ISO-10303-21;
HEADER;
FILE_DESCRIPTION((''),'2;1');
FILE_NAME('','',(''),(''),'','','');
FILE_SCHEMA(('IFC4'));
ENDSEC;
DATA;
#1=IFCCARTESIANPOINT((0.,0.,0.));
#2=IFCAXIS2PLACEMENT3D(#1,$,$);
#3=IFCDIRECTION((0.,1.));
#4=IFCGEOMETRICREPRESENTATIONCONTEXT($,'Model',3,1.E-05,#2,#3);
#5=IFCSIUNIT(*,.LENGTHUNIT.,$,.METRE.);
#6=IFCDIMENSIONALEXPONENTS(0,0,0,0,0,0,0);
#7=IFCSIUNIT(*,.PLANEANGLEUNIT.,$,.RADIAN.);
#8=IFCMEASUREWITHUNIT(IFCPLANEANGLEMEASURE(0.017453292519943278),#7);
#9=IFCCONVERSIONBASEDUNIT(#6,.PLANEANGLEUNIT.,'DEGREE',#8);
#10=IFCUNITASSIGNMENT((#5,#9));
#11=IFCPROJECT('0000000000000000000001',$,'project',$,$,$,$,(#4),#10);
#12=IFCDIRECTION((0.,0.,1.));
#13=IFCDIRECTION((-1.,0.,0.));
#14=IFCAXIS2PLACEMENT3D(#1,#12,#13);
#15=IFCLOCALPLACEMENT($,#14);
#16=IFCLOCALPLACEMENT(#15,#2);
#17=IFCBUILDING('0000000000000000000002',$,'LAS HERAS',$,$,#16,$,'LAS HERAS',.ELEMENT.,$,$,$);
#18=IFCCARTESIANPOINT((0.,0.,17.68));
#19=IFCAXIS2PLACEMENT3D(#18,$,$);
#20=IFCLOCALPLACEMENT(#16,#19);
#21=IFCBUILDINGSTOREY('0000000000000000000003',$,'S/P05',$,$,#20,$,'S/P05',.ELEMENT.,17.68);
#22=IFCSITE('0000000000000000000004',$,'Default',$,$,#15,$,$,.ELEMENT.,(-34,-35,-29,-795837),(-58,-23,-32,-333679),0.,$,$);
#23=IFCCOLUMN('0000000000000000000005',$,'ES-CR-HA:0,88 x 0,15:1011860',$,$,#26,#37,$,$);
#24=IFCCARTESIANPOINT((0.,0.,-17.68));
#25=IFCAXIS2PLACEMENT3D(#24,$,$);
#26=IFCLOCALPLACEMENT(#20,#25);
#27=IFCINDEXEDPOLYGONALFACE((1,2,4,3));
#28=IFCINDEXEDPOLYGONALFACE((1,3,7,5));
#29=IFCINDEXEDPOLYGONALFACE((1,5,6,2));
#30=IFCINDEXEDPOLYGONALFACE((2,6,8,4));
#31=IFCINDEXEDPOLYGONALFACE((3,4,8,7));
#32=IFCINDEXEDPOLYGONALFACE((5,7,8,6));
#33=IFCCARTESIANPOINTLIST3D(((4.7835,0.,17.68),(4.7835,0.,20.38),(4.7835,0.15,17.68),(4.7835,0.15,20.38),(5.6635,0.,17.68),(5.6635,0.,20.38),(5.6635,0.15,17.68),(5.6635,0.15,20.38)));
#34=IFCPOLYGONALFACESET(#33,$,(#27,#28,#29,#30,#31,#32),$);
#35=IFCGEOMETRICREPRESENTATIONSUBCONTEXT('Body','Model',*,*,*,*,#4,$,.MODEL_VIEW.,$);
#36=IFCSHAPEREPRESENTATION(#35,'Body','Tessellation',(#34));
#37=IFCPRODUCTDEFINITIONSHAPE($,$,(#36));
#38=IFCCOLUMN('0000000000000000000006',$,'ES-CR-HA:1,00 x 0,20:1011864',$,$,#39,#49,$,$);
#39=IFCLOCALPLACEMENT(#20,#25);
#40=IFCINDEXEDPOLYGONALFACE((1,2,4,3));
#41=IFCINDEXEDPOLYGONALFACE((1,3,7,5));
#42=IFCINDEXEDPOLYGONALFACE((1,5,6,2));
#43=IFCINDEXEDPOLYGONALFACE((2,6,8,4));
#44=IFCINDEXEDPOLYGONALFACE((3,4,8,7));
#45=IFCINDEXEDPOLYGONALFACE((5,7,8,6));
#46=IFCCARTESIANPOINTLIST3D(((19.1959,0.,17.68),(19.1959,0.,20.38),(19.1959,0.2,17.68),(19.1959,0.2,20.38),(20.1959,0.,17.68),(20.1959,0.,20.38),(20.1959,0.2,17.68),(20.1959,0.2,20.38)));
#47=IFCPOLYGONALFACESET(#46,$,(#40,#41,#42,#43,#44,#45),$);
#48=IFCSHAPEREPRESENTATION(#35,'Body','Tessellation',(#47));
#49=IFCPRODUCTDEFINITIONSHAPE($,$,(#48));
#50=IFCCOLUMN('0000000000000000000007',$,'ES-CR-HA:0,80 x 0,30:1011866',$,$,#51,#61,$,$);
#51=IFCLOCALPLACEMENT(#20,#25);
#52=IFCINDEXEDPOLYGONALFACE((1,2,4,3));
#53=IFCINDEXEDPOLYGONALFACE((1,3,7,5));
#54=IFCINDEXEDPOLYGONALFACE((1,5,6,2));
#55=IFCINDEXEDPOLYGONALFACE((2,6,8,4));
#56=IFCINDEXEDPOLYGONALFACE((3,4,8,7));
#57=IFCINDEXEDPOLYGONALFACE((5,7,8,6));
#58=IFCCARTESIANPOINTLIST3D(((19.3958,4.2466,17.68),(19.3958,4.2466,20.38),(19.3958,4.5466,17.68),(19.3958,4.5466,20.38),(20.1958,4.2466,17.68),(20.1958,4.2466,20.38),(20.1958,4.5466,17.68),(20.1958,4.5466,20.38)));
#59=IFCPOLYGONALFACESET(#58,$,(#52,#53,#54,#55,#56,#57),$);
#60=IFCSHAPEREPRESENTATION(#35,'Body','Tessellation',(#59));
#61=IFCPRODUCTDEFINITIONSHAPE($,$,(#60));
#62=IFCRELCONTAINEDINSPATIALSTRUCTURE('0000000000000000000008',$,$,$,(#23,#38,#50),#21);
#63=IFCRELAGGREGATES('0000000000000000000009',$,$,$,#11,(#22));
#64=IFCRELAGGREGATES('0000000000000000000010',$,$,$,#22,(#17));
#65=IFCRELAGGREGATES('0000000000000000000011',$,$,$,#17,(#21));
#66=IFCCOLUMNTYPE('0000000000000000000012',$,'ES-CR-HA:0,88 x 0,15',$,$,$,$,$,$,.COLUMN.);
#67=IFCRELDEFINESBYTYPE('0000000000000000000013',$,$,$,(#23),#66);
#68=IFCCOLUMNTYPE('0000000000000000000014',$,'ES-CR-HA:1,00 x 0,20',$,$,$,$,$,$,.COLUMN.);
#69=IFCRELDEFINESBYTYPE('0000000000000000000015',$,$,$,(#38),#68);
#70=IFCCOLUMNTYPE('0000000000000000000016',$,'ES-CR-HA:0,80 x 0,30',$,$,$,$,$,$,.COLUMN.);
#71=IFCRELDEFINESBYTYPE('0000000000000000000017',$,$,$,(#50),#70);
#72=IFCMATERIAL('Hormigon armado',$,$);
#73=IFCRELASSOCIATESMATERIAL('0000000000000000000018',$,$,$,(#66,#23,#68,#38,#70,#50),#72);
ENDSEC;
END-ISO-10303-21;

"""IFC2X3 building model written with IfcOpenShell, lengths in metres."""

from ifc_helpers import new_model, entity, si_unit, converted_unit, direction, frame, frame_2d, origin, origin_2d_with_axis, place, context, subcontext, project, spatial, rectangle, extrude, source, transform, mapped, material, type_object, type_shapes, element, save


model = new_model("IFC2X3")

# Units and contexts
model_context = context("Model", 3, precision=1e-05, world=origin(), true_north=direction((0.0, 1.0)))
body_context = subcontext(model_context, "Body", "Model", "MODEL_VIEW")
ifc_project = project(units=[si_unit("LENGTHUNIT", "METRE"), converted_unit("PLANEANGLEUNIT", "DEGREE", entity("IfcPlaneAngleMeasure", 0.017453292519943278), si_unit("PLANEANGLEUNIT", "RADIAN"), dimensions=[0, 0, 0, 0, 0, 0, 0])], contexts=[model_context])

# Site, building, storey
site_placement = place(None, frame((0.0, 0.0, 0.0), z_axis=(0.0, 0.0, 1.0), x_axis=(-1.0, 0.0, 0.0)))
site = spatial("IfcSite", under=ifc_project, at=site_placement, Name="Default", CompositionType="ELEMENT", RefLatitude=(-34, -35, -29, -795837), RefLongitude=(-58, -23, -32, -333679), RefElevation=0.0)
building_placement = place(site_placement, origin())
building = spatial("IfcBuilding", under=site, at=building_placement, Name="LAS HERAS", LongName="LAS HERAS", CompositionType="ELEMENT")
storey_placement = place(building_placement, frame((0.0, 0.0, 17.68)))
storey = spatial("IfcBuildingStorey", under=building, at=storey_placement, Name="S/P05", LongName="S/P05", CompositionType="ELEMENT", Elevation=17.68)

# Columns
ifc_material = material(Name="Hormigon armado")
column_type_1 = type_object("IfcColumnType", Name="ES-CR-HA:0,88 x 0,15", PredefinedType="COLUMN", material=ifc_material)
shared_shape_1 = source(origin(), body_context, "Body", "SweptSolid", [
    extrude(rectangle(XDim=2.7, YDim=0.15, at=frame_2d((0.0, 0.0), x_axis=(1.0, 0.0))), frame((4.7835, 0.075, 19.03), z_axis=(1.0, 0.0, 0.0), x_axis=(0.0, 0.0, 1.0)), (0.0, 0.0, 1.0), 0.88),
])
type_shapes(column_type_1, [shared_shape_1])
column_1_placement = place(storey_placement, frame((0.0, 0.0, -17.68)))
element("IfcColumn", 1, at=column_1_placement, inside=storey, type_object=column_type_1, material=ifc_material, Name="ES-CR-HA:0,88 x 0,15:1011860", context=body_context, shape_type="MappedRepresentation", body=[
    mapped(shared_shape_1, transform((0.0, 0.0, 0.0), scale=1.0)),
])
column_type_2 = type_object("IfcColumnType", Name="ES-CR-HA:1,00 x 0,20", PredefinedType="COLUMN", material=ifc_material)
shared_shape_2 = source(origin(), body_context, "Body", "SweptSolid", [
    extrude(rectangle(XDim=2.7, YDim=0.2, at=frame_2d((0.0, 0.0), x_axis=(1.0, 0.0))), frame((19.1959, 0.1, 19.03), z_axis=(1.0, 0.0, 0.0), x_axis=(0.0, 0.0, 1.0)), (0.0, 0.0, 1.0), 1.0),
])
type_shapes(column_type_2, [shared_shape_2])
column_2_placement = place(storey_placement, frame((0.0, 0.0, -17.68)))
element("IfcColumn", 2, at=column_2_placement, inside=storey, type_object=column_type_2, material=ifc_material, Name="ES-CR-HA:1,00 x 0,20:1011864", context=body_context, shape_type="MappedRepresentation", body=[
    mapped(shared_shape_2, transform((0.0, 0.0, 0.0), scale=1.0)),
])
column_type_3 = type_object("IfcColumnType", Name="ES-CR-HA:0,80 x 0,30", PredefinedType="COLUMN", material=ifc_material)
shared_shape_3 = source(origin(), body_context, "Body", "SweptSolid", [
    extrude(rectangle(XDim=2.7, YDim=0.3, at=origin_2d_with_axis()), frame((19.3958, 4.3966, 19.03), z_axis=(1.0, 0.0, 0.0), x_axis=(0.0, 0.0, 1.0)), (0.0, 0.0, 1.0), 0.8),
])
type_shapes(column_type_3, [shared_shape_3])
column_3_placement = place(storey_placement, frame((0.0, 0.0, -17.68)))
element("IfcColumn", 3, at=column_3_placement, inside=storey, type_object=column_type_3, material=ifc_material, Name="ES-CR-HA:0,80 x 0,30:1011866", context=body_context, shape_type="MappedRepresentation", body=[
    mapped(shared_shape_3, transform((0.0, 0.0, 0.0), scale=1.0)),
])

save(model, "model.ifc")
